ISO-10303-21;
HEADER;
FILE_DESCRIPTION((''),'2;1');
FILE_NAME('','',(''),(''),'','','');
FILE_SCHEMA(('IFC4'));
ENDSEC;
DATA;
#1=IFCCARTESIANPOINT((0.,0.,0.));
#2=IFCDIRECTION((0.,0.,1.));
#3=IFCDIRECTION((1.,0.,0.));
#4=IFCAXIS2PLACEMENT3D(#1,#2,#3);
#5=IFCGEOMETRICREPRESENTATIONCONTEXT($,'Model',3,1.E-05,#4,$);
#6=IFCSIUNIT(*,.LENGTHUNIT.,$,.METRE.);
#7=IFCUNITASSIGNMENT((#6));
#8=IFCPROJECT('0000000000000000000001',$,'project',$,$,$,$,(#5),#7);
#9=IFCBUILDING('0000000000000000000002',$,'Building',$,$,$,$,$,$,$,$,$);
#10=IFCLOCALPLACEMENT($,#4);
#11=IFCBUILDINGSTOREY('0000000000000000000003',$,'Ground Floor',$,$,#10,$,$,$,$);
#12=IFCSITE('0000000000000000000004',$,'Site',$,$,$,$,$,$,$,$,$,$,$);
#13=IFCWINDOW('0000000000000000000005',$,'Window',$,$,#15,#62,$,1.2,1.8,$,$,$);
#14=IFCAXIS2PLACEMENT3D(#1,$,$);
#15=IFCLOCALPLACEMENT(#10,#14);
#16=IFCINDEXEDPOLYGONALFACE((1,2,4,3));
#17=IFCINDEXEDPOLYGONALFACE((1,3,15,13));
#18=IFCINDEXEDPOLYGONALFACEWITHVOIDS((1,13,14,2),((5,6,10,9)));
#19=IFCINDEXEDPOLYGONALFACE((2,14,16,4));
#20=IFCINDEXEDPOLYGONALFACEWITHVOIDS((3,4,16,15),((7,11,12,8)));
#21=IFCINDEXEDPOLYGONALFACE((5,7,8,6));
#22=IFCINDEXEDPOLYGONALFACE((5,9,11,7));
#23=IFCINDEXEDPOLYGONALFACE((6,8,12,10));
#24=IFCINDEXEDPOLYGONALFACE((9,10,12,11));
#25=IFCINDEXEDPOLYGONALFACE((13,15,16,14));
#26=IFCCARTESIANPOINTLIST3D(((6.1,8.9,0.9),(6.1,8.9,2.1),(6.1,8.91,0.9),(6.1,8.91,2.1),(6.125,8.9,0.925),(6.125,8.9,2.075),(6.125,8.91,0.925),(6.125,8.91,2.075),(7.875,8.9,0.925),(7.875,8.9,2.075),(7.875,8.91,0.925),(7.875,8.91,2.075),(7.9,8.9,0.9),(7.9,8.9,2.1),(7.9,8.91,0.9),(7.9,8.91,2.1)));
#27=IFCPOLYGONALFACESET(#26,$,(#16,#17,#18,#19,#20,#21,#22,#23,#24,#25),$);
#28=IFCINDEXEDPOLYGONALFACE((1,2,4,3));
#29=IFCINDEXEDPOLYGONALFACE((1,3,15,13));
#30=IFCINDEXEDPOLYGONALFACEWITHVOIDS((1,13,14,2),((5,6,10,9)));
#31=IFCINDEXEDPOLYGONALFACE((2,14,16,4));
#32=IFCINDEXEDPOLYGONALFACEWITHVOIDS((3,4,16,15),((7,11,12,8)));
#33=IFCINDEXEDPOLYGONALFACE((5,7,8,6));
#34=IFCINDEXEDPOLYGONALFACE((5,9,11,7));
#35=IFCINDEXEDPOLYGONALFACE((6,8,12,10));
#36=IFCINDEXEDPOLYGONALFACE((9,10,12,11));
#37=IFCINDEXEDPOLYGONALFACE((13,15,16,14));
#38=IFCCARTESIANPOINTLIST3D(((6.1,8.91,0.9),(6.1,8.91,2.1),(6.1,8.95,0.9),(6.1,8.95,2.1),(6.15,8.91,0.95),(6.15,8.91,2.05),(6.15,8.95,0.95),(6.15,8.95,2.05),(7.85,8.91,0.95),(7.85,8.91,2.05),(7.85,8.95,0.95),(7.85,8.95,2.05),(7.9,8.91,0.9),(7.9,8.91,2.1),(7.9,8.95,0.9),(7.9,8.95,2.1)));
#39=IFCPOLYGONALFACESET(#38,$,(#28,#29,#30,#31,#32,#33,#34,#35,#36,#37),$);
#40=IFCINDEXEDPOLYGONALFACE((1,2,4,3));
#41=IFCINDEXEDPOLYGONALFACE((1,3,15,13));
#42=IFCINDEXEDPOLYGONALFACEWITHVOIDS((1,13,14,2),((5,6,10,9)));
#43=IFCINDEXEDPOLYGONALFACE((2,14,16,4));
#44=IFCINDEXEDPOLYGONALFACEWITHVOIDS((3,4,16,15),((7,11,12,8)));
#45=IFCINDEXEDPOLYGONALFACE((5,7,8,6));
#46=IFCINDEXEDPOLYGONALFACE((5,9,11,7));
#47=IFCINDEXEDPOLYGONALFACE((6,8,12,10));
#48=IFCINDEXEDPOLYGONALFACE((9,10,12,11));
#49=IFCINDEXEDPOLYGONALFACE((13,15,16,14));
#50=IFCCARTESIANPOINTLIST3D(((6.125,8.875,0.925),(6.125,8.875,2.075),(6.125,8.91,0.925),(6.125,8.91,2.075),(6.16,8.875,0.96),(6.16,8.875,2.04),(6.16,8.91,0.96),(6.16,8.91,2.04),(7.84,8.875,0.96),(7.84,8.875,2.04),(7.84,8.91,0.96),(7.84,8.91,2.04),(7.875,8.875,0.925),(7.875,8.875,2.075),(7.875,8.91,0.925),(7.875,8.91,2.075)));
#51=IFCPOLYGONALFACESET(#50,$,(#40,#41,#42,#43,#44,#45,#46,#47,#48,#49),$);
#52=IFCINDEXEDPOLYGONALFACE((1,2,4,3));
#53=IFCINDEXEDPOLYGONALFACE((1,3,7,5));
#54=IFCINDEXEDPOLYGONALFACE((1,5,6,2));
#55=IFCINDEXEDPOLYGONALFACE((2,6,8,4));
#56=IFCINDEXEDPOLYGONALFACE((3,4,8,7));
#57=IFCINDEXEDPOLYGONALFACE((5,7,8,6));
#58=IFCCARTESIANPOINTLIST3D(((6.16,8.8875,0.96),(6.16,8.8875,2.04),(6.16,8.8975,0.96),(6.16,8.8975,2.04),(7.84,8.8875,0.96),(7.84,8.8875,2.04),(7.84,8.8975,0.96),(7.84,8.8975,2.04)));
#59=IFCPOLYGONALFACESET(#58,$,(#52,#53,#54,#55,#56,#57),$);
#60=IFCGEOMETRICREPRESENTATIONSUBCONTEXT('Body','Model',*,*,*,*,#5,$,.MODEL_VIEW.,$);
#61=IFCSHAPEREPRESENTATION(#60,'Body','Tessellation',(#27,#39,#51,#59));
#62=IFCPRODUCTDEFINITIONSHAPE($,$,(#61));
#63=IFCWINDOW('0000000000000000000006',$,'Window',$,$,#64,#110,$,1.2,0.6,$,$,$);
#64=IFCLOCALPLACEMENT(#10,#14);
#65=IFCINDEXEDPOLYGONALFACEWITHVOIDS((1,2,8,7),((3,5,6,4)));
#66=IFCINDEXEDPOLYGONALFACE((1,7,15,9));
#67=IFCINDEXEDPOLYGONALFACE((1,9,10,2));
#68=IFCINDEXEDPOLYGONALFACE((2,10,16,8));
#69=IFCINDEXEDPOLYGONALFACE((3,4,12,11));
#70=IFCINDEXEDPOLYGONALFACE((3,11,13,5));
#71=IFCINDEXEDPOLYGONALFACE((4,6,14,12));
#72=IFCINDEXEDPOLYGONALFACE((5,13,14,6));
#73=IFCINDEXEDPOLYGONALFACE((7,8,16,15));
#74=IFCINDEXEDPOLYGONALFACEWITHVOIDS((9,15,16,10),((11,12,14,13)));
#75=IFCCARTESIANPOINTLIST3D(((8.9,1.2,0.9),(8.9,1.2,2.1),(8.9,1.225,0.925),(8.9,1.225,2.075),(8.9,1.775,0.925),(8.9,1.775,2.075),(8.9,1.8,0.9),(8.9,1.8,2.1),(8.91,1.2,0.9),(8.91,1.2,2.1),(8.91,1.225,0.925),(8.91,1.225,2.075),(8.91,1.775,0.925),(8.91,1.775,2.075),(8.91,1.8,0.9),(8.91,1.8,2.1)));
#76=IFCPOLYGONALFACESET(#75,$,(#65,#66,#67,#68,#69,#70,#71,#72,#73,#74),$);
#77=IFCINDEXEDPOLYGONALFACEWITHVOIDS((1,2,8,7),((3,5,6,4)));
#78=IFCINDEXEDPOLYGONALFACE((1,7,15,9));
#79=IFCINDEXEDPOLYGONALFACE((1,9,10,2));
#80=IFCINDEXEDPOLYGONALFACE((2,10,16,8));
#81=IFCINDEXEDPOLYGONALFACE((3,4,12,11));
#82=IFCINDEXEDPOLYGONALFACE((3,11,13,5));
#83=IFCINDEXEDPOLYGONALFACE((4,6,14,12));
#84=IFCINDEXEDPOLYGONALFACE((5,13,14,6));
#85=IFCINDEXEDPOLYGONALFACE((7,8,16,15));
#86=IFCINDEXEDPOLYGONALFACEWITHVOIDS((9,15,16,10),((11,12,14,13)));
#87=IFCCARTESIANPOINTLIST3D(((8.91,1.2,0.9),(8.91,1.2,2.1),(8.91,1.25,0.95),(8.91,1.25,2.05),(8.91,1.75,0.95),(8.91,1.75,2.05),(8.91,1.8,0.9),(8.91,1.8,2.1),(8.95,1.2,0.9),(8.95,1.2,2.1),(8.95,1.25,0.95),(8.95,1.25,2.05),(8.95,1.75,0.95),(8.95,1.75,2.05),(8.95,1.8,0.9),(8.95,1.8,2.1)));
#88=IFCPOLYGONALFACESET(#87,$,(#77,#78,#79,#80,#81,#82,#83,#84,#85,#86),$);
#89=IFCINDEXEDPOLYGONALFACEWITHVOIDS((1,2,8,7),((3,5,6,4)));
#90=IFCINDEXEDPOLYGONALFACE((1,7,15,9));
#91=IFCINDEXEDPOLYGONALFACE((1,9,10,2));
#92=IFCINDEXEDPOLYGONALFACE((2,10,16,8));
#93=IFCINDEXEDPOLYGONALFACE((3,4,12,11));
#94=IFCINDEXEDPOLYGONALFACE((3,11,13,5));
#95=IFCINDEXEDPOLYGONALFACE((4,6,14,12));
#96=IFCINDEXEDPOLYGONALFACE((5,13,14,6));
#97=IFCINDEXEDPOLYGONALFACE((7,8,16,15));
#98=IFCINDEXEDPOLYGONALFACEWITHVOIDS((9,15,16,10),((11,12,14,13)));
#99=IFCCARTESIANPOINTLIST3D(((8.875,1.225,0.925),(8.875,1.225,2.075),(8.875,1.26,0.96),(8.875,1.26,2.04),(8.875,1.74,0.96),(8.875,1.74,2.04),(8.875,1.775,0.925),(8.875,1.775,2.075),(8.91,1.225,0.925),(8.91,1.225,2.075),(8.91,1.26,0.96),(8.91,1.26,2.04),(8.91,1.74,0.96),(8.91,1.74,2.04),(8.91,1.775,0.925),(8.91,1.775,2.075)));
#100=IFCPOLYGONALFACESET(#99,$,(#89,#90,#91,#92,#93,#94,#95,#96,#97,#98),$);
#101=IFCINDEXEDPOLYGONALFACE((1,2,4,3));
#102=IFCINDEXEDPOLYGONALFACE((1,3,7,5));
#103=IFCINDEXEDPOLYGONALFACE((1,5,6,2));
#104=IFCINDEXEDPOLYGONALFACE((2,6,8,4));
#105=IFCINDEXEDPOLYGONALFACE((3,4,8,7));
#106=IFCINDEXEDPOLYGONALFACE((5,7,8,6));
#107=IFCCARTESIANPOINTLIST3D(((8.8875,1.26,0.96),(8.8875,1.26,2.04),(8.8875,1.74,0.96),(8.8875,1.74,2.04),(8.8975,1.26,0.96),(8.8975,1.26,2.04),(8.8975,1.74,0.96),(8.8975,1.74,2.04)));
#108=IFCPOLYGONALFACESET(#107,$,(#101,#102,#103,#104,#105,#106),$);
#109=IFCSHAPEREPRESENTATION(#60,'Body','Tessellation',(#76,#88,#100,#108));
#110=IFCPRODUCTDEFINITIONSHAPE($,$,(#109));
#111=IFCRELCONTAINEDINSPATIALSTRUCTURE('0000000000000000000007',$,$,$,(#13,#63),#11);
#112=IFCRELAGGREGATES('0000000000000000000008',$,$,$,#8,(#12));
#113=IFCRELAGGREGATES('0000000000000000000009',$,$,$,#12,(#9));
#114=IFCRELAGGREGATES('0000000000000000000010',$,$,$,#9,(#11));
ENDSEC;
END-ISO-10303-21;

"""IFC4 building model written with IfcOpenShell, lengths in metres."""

from ifc_helpers import new_model, si_unit, frame, origin_with_axes, place, context, subcontext, project, spatial, line, indexed_curve, outline, extrude, element, save


model = new_model("IFC4")

# Units and contexts
model_context = context("Model", 3, precision=1e-05, world=origin_with_axes())
body_context = subcontext(model_context, "Body", "Model", "MODEL_VIEW")
ifc_project = project(units=[si_unit("LENGTHUNIT", "METRE")], contexts=[model_context])

# Site, building, storey
site = spatial("IfcSite", under=ifc_project, Name="Site")
building = spatial("IfcBuilding", under=site, Name="Building")
storey_placement = place(None, origin_with_axes())
storey = spatial("IfcBuildingStorey", under=building, at=storey_placement, Name="Ground Floor")

# Windows
window_1_placement = place(storey_placement, frame((7.9, 9.0, 0.9), z_axis=(0.0, 0.0, 1.0), x_axis=(-1.0, 0.0, 0.0)))
element("IfcWindow", 1, at=window_1_placement, inside=storey, Name="Window", OverallHeight=1.2, OverallWidth=1.8, context=body_context, shape_type="SweptSolid", body=[
    extrude(outline(indexed_curve([(0.0, 0.0), (1.8, 0.0), (1.8, 1.2), (0.0, 1.2)], segments=[line(1, 2, 3, 4, 1)]), holes=[indexed_curve([(0.025, 0.025), (1.775, 0.025), (1.775, 1.175), (0.025, 1.175)], segments=[line(1, 2, 3, 4, 1)])]), frame((0.0, 0.09, 0.0), z_axis=(0.0, -1.0, 0.0), x_axis=(1.0, 0.0, 0.0)), (0.0, 0.0, -1.0), 0.01),
    extrude(outline(indexed_curve([(0.0, 0.0), (1.8, 0.0), (1.8, 1.2), (0.0, 1.2)], segments=[line(1, 2, 3, 4, 1)]), holes=[indexed_curve([(0.05, 0.05), (1.75, 0.05), (1.75, 1.15), (0.05, 1.15)], segments=[line(1, 2, 3, 4, 1)])]), frame((0.0, 0.05, 0.0), z_axis=(0.0, -1.0, 0.0), x_axis=(1.0, 0.0, 0.0)), (0.0, 0.0, -1.0), 0.04),
    extrude(outline(indexed_curve([(0.0, 0.0), (1.75, 0.0), (1.75, 1.15), (0.0, 1.15)], segments=[line(1, 2, 3, 4, 1)]), holes=[indexed_curve([(0.035, 0.035), (1.715, 0.035), (1.715, 1.115), (0.035, 1.115)], segments=[line(1, 2, 3, 4, 1)])]), frame((0.025, 0.09, 0.025), z_axis=(0.0, -1.0, 0.0), x_axis=(1.0, 0.0, 0.0)), (0.0, 0.0, -1.0), 0.035),
    extrude(outline(indexed_curve([(0.035, 0.035), (1.715, 0.035), (1.715, 1.115), (0.035, 1.115)], segments=[line(1, 2, 3, 4, 1)])), frame((0.025, 0.1025, 0.025), z_axis=(0.0, -1.0, 0.0), x_axis=(1.0, 0.0, 0.0)), (0.0, 0.0, -1.0), 0.01),
])
window_2_placement = place(storey_placement, frame((9.0, 1.2, 0.9), z_axis=(0.0, 0.0, 1.0), x_axis=(0.0, 1.0, 0.0)))
element("IfcWindow", 2, at=window_2_placement, inside=storey, Name="Window", OverallHeight=1.2, OverallWidth=0.6, context=body_context, shape_type="SweptSolid", body=[
    extrude(outline(indexed_curve([(0.0, 0.0), (0.6, 0.0), (0.6, 1.2), (0.0, 1.2)], segments=[line(1, 2, 3, 4, 1)]), holes=[indexed_curve([(0.025, 0.025), (0.575, 0.025), (0.575, 1.175), (0.025, 1.175)], segments=[line(1, 2, 3, 4, 1)])]), frame((0.0, 0.09, 0.0), z_axis=(0.0, -1.0, 0.0), x_axis=(1.0, 0.0, 0.0)), (0.0, 0.0, -1.0), 0.01),
    extrude(outline(indexed_curve([(0.0, 0.0), (0.6, 0.0), (0.6, 1.2), (0.0, 1.2)], segments=[line(1, 2, 3, 4, 1)]), holes=[indexed_curve([(0.05, 0.05), (0.55, 0.05), (0.55, 1.15), (0.05, 1.15)], segments=[line(1, 2, 3, 4, 1)])]), frame((0.0, 0.05, 0.0), z_axis=(0.0, -1.0, 0.0), x_axis=(1.0, 0.0, 0.0)), (0.0, 0.0, -1.0), 0.04),
    extrude(outline(indexed_curve([(0.0, 0.0), (0.55, 0.0), (0.55, 1.15), (0.0, 1.15)], segments=[line(1, 2, 3, 4, 1)]), holes=[indexed_curve([(0.035, 0.035), (0.515, 0.035), (0.515, 1.115), (0.035, 1.115)], segments=[line(1, 2, 3, 4, 1)])]), frame((0.025, 0.09, 0.025), z_axis=(0.0, -1.0, 0.0), x_axis=(1.0, 0.0, 0.0)), (0.0, 0.0, -1.0), 0.035),
    extrude(outline(indexed_curve([(0.035, 0.035), (0.515, 0.035), (0.515, 1.115), (0.035, 1.115)], segments=[line(1, 2, 3, 4, 1)])), frame((0.025, 0.1025, 0.025), z_axis=(0.0, -1.0, 0.0), x_axis=(1.0, 0.0, 0.0)), (0.0, 0.0, -1.0), 0.01),
])

save(model, "model.ifc")
